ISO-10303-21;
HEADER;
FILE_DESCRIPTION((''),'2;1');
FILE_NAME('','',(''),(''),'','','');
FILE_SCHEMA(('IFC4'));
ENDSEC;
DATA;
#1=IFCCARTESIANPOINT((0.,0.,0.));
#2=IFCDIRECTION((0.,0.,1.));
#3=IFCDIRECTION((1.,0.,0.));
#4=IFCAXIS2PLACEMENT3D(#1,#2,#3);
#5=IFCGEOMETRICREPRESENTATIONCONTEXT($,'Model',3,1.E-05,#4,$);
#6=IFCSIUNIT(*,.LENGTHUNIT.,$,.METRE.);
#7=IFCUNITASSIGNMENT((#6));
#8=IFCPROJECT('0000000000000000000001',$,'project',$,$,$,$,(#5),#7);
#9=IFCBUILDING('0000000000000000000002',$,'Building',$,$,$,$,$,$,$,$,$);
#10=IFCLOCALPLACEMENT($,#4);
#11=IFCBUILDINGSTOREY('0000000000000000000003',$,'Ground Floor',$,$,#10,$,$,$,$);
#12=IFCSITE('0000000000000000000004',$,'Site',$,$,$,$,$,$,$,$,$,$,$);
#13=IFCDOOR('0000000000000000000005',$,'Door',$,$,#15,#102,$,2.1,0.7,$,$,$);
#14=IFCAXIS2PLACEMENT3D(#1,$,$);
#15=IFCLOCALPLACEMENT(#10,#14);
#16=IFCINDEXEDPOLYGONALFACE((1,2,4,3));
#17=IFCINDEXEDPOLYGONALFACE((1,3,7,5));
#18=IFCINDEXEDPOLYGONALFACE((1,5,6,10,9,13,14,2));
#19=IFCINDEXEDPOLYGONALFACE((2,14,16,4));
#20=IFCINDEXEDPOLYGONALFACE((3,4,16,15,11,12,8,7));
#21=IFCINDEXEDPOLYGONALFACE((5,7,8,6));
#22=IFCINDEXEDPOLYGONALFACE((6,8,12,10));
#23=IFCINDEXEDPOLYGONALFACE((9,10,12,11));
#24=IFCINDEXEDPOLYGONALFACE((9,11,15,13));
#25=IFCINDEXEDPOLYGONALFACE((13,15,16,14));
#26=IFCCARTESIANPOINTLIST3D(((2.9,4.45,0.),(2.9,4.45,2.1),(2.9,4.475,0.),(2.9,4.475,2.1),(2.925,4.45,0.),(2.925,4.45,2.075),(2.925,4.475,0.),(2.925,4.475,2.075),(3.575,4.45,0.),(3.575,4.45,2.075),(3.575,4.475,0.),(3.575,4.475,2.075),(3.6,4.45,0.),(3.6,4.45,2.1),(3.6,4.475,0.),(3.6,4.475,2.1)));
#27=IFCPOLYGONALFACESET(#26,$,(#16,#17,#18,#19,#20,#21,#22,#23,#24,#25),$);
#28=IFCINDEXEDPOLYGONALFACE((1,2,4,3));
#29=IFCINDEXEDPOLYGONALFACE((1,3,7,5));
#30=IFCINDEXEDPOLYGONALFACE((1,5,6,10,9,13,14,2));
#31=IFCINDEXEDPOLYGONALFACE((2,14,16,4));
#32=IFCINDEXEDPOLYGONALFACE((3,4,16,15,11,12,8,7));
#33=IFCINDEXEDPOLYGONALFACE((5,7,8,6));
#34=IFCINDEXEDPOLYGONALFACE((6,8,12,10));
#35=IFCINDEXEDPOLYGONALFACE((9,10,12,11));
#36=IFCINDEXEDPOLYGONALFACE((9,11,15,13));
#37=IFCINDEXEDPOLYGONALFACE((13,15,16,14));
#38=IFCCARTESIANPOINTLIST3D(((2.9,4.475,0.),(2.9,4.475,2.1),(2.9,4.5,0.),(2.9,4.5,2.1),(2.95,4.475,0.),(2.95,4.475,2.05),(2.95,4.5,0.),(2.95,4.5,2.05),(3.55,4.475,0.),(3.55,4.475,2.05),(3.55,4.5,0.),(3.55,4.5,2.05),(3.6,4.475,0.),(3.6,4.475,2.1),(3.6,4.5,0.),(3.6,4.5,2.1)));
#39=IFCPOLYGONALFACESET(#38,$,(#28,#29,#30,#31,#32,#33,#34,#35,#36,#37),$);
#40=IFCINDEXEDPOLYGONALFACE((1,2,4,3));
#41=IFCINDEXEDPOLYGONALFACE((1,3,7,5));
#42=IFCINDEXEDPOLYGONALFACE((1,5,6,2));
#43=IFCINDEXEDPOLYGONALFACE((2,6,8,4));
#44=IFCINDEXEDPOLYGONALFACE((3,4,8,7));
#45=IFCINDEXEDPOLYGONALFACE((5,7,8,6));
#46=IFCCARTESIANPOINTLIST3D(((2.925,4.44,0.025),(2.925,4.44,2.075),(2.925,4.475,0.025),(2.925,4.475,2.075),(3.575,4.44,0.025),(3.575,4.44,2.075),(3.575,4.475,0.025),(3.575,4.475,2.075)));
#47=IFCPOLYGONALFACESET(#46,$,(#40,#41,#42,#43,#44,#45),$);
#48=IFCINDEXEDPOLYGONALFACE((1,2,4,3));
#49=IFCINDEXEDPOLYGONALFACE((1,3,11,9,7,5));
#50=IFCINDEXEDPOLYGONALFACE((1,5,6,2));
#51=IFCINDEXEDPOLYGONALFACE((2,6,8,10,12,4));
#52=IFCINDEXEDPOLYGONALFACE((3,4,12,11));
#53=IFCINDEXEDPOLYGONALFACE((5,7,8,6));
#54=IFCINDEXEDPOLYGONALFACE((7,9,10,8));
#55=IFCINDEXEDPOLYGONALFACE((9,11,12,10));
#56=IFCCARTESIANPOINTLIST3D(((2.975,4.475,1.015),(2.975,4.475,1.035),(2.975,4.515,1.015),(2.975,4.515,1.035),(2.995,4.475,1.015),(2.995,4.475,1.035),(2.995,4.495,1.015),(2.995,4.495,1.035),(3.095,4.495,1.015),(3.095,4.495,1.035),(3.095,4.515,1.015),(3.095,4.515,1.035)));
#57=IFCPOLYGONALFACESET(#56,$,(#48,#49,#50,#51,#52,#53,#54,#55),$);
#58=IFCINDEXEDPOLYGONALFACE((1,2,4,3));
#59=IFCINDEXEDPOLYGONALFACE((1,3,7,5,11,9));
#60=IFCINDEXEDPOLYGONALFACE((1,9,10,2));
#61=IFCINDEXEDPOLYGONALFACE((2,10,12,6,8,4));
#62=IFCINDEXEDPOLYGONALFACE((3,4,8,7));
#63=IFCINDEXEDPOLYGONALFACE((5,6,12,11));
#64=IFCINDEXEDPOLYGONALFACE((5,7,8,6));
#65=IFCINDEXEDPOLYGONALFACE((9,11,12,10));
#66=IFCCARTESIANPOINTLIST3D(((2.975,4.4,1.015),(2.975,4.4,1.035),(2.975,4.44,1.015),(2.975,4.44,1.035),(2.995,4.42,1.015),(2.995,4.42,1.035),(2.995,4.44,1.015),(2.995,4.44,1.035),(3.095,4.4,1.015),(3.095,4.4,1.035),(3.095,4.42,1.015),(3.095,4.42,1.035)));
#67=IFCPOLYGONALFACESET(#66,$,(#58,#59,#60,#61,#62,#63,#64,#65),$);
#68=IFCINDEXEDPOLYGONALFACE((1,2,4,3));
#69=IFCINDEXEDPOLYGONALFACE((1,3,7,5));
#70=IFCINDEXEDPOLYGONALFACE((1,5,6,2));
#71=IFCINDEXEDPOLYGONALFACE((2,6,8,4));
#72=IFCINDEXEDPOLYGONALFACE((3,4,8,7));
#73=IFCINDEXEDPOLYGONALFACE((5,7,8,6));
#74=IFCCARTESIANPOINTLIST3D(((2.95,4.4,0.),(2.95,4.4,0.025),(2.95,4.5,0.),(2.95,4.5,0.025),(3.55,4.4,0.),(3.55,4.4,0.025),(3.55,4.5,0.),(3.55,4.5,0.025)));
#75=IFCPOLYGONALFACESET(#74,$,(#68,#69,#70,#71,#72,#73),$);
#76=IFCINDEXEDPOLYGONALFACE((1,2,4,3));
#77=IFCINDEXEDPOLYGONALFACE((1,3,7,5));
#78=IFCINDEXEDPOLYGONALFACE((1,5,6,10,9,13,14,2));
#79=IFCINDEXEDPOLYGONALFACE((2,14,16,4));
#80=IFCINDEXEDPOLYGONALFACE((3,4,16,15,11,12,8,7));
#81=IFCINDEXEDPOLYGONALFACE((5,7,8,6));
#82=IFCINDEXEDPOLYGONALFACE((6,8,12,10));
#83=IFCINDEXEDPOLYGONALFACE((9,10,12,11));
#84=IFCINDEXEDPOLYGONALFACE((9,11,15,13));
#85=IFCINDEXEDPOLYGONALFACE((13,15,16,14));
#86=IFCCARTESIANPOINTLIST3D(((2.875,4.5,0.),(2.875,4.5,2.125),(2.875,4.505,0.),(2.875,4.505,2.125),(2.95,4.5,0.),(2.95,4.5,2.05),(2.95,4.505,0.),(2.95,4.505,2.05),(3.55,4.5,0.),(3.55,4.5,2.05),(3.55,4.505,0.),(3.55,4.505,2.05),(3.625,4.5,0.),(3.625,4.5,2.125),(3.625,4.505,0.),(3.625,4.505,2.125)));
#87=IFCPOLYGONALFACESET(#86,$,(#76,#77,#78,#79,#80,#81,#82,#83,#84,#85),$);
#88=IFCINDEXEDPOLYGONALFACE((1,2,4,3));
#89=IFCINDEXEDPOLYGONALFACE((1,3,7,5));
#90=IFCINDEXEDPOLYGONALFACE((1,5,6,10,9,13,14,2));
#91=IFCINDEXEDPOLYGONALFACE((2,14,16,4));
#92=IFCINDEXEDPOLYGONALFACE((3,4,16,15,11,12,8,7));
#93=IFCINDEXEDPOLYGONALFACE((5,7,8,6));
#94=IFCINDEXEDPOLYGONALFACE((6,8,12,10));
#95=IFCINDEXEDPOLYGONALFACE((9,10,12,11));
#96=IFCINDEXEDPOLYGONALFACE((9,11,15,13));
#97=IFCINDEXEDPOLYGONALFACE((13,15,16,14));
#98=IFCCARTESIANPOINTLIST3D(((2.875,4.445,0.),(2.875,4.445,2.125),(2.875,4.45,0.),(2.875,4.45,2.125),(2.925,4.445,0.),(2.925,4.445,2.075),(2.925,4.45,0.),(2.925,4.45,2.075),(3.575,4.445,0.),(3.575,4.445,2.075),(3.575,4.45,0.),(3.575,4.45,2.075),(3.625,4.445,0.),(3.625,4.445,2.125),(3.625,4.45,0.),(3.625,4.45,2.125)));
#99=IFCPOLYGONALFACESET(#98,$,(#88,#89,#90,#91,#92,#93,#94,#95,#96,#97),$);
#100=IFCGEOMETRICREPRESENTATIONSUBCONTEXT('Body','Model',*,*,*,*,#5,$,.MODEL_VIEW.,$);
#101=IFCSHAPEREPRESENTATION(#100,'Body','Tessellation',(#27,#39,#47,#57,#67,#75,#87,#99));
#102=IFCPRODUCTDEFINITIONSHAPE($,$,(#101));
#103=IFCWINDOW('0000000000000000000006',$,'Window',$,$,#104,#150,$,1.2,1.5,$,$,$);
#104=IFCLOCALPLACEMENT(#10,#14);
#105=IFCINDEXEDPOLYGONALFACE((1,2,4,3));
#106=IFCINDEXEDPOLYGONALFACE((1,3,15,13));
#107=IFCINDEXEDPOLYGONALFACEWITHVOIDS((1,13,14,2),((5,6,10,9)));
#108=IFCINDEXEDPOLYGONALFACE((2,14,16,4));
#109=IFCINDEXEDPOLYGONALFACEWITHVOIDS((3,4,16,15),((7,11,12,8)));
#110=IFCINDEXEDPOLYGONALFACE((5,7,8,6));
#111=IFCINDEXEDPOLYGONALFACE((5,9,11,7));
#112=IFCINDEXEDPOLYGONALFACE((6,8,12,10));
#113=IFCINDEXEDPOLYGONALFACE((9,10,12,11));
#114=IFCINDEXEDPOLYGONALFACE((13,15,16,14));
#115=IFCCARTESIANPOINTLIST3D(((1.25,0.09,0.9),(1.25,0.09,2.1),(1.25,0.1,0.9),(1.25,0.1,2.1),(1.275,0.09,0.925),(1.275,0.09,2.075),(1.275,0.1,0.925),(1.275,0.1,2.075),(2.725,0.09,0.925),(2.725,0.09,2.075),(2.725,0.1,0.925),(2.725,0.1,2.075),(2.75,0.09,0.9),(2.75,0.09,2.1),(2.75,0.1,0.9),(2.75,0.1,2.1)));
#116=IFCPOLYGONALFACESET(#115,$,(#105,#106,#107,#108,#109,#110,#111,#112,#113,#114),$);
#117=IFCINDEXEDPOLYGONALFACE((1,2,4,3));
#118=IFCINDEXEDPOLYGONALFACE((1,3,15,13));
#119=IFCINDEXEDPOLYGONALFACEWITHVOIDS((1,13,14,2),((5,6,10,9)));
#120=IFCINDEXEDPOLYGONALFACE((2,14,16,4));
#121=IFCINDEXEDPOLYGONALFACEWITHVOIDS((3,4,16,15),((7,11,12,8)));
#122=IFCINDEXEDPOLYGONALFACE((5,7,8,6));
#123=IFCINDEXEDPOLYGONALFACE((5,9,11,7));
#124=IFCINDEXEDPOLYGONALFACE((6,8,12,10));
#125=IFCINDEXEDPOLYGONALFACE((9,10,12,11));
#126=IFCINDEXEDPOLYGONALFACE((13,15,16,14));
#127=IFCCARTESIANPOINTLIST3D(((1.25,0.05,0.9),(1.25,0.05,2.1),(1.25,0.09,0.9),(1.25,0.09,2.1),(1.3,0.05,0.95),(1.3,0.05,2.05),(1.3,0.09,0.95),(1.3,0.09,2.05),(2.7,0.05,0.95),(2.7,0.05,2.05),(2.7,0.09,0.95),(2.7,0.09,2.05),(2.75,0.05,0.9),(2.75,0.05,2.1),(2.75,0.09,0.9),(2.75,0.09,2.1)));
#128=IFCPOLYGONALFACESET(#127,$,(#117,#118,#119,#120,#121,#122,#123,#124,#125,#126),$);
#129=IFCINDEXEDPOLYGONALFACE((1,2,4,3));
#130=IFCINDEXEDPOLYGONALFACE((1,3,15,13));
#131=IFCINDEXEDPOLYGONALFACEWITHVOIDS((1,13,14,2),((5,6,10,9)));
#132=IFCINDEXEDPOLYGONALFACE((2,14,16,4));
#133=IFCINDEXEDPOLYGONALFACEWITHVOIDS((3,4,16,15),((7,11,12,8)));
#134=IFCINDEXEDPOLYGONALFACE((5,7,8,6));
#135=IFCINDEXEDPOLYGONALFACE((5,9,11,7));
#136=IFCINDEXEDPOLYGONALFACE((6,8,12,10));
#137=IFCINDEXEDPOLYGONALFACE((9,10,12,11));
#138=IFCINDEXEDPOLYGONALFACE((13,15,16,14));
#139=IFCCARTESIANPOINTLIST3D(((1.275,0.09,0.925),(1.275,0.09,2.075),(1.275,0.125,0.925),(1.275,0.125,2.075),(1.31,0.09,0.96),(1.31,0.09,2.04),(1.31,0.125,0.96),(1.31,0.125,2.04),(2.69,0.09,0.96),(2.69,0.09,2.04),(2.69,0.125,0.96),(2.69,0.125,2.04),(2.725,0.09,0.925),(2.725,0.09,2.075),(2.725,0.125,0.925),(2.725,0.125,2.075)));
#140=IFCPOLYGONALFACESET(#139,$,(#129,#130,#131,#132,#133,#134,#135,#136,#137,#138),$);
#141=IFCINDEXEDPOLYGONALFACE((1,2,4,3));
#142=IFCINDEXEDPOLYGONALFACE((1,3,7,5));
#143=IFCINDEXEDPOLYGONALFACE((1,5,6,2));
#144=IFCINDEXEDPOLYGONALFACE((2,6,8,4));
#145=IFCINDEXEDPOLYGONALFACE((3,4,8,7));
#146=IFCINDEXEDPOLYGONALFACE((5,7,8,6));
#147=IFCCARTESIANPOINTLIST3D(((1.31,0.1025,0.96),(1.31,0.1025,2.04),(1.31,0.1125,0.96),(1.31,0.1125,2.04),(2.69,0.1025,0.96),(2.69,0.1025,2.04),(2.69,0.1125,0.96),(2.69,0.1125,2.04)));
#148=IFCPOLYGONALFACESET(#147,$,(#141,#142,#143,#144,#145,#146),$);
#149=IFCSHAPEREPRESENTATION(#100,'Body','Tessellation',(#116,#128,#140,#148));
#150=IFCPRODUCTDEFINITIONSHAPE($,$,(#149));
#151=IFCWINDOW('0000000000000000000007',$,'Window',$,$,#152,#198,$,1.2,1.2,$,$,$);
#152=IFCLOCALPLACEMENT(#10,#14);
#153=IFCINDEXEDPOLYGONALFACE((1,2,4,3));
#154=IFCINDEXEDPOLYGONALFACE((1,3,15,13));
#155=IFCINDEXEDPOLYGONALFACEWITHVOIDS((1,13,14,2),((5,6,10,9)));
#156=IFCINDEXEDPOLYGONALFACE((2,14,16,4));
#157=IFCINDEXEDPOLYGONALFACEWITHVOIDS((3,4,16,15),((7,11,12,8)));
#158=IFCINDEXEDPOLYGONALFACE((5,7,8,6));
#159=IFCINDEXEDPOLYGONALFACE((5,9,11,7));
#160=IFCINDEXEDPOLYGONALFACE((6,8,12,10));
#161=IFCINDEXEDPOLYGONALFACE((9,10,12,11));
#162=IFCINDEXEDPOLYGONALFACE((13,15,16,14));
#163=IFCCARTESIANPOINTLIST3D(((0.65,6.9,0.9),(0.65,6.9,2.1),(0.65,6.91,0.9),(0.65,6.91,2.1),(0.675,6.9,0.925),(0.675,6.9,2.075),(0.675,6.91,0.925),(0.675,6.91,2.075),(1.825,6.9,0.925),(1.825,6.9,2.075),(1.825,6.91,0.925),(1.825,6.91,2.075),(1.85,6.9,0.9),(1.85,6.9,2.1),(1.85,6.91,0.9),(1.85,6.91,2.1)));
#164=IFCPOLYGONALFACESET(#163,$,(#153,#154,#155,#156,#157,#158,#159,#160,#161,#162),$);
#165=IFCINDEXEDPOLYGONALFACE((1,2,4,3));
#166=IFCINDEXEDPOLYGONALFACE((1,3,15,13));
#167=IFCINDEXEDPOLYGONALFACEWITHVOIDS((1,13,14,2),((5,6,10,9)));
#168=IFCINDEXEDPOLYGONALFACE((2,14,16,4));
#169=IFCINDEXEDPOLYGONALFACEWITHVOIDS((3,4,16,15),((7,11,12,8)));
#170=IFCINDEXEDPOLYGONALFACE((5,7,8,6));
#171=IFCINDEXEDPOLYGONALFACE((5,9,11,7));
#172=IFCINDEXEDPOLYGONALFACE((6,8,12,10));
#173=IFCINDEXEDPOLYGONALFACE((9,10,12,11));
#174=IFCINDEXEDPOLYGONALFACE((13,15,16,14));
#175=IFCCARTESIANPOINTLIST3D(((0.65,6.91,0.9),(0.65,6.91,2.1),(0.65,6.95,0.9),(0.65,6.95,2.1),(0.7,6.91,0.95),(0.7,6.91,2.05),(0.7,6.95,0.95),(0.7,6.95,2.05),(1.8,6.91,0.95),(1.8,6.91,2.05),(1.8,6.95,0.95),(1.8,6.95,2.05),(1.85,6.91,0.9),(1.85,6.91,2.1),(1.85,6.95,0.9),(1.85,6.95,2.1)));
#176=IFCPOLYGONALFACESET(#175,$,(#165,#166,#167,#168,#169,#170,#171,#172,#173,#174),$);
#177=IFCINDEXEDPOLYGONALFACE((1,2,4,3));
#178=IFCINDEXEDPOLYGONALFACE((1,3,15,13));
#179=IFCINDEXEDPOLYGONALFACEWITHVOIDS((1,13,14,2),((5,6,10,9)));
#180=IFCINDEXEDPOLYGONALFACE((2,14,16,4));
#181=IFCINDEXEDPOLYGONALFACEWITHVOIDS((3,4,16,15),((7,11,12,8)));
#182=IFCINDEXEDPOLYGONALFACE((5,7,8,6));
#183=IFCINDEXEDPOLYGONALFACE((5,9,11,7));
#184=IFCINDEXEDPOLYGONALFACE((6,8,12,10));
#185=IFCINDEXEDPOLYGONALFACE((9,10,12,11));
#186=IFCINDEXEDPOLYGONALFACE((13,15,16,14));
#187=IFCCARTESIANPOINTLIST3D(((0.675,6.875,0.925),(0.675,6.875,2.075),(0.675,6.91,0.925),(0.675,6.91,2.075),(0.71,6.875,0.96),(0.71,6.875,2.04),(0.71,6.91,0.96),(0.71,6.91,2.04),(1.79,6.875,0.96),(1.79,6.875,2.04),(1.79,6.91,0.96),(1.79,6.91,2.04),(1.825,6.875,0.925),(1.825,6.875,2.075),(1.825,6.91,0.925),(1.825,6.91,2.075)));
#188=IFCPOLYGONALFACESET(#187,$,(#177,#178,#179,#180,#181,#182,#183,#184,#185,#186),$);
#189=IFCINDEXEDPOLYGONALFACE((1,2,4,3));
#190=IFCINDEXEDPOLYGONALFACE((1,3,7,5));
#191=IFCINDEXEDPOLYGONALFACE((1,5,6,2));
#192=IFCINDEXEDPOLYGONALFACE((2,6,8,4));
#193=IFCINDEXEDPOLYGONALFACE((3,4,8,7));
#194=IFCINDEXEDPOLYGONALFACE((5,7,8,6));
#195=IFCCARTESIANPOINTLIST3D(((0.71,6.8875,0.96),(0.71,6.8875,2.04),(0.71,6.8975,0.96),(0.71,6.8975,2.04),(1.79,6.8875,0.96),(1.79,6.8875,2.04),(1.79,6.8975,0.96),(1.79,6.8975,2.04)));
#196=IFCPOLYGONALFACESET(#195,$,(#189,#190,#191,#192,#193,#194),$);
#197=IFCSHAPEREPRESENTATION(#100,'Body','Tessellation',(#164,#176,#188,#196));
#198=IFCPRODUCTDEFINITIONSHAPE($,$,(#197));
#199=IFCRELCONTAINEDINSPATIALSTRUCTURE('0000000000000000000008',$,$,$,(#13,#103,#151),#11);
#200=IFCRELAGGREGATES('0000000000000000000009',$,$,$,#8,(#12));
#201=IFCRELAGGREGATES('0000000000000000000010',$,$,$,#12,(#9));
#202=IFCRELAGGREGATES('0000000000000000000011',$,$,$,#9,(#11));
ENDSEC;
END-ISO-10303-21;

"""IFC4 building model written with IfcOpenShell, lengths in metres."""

from ifc_helpers import new_model, si_unit, frame, origin_with_axes, place, context, subcontext, project, spatial, line, indexed_curve, outline, extrude, element, save


model = new_model("IFC4")

# Units and contexts
model_context = context("Model", 3, precision=1e-05, world=origin_with_axes())
body_context = subcontext(model_context, "Body", "Model", "MODEL_VIEW")
ifc_project = project(units=[si_unit("LENGTHUNIT", "METRE")], contexts=[model_context])

# Site, building, storey
site = spatial("IfcSite", under=ifc_project, Name="Site")
building = spatial("IfcBuilding", under=site, Name="Building")
storey_placement = place(None, origin_with_axes())
storey = spatial("IfcBuildingStorey", under=building, at=storey_placement, Name="Ground Floor")

# Door
door_1_placement = place(storey_placement, frame((3.6, 4.5, 0.0), z_axis=(0.0, 0.0, 1.0), x_axis=(-1.0, 0.0, 0.0)))
element("IfcDoor", 1, at=door_1_placement, inside=storey, Name="Door", OverallHeight=2.1, OverallWidth=0.7, context=body_context, shape_type="SweptSolid", body=[
    extrude(outline(indexed_curve([(0.0, 0.0), (0.0, 2.1), (0.7, 2.1), (0.7, 0.0), (0.675, 0.0), (0.675, 2.075), (0.025, 2.075), (0.025, 0.0)], segments=[line(1, 2, 3, 4, 5, 6, 7, 8, 1)])), frame((0.0, 0.025, 0.0), z_axis=(0.0, -1.0, 0.0), x_axis=(1.0, 0.0, 0.0)), (0.0, 0.0, -1.0), 0.025),
    extrude(outline(indexed_curve([(0.0, 0.0), (0.0, 2.1), (0.7, 2.1), (0.7, 0.0), (0.65, 0.0), (0.65, 2.05), (0.05, 2.05), (0.05, 0.0)], segments=[line(1, 2, 3, 4, 5, 6, 7, 8, 1)])), frame((0.0, 0.0, 0.0), z_axis=(0.0, -1.0, 0.0), x_axis=(1.0, 0.0, 0.0)), (0.0, 0.0, -1.0), 0.025),
    extrude(outline(indexed_curve([(0.0, 0.0), (0.65, 0.0), (0.65, 0.035), (0.0, 0.035)], segments=[line(1, 2, 3, 4, 1)])), frame((0.025, 0.025, 0.025), z_axis=(0.0, 0.0, 1.0), x_axis=(1.0, 0.0, 0.0)), (0.0, 0.0, 1.0), 2.05),
    extrude(outline(indexed_curve([(0.0, 0.0), (0.0, -0.04), (-0.12, -0.04), (-0.12, -0.02), (-0.02, -0.02), (-0.02, 0.0)], segments=[line(1, 2, 3, 4, 5, 6, 1)])), frame((0.625, 0.025, 1.015), z_axis=(0.0, 0.0, 1.0), x_axis=(1.0, 0.0, 0.0)), (0.0, 0.0, 1.0), 0.02),
    extrude(outline(indexed_curve([(0.0, 0.0), (0.0, 0.04), (-0.12, 0.04), (-0.12, 0.02), (-0.02, 0.02), (-0.02, 0.0)], segments=[line(1, 2, 3, 4, 5, 6, 1)])), frame((0.625, 0.06, 1.015), z_axis=(0.0, 0.0, 1.0), x_axis=(1.0, 0.0, 0.0)), (0.0, 0.0, 1.0), 0.02),
    extrude(outline(indexed_curve([(0.0, 0.0), (0.6, 0.0), (0.6, 0.1), (0.0, 0.1)], segments=[line(1, 2, 3, 4, 1)])), frame((0.05, 0.0, 0.0), z_axis=(0.0, 0.0, 1.0), x_axis=(1.0, 0.0, 0.0)), (0.0, 0.0, 1.0), 0.025),
    extrude(outline(indexed_curve([(0.0, 0.0), (0.0, 2.125), (0.75, 2.125), (0.75, 0.0), (0.675, 0.0), (0.675, 2.05), (0.075, 2.05), (0.075, 0.0)], segments=[line(1, 2, 3, 4, 5, 6, 7, 8, 1)])), frame((-0.025, -0.005, 0.0), z_axis=(0.0, -1.0, 0.0), x_axis=(1.0, 0.0, 0.0)), (0.0, 0.0, -1.0), 0.005),
    extrude(outline(indexed_curve([(0.0, 0.0), (0.0, 2.125), (0.75, 2.125), (0.75, 0.0), (0.7, 0.0), (0.7, 2.075), (0.05, 2.075), (0.05, 0.0)], segments=[line(1, 2, 3, 4, 5, 6, 7, 8, 1)])), frame((-0.025, 0.05, 0.0), z_axis=(0.0, -1.0, 0.0), x_axis=(1.0, 0.0, 0.0)), (0.0, 0.0, -1.0), 0.005),
])

# Windows
window_1_placement = place(storey_placement, frame((1.25, 0.0, 0.9), z_axis=(0.0, 0.0, 1.0), x_axis=(1.0, 0.0, 0.0)))
element("IfcWindow", 2, at=window_1_placement, inside=storey, Name="Window", OverallHeight=1.2, OverallWidth=1.5, context=body_context, shape_type="SweptSolid", body=[
    extrude(outline(indexed_curve([(0.0, 0.0), (1.5, 0.0), (1.5, 1.2), (0.0, 1.2)], segments=[line(1, 2, 3, 4, 1)]), holes=[indexed_curve([(0.025, 0.025), (1.475, 0.025), (1.475, 1.175), (0.025, 1.175)], segments=[line(1, 2, 3, 4, 1)])]), frame((0.0, 0.09, 0.0), z_axis=(0.0, -1.0, 0.0), x_axis=(1.0, 0.0, 0.0)), (0.0, 0.0, -1.0), 0.01),
    extrude(outline(indexed_curve([(0.0, 0.0), (1.5, 0.0), (1.5, 1.2), (0.0, 1.2)], segments=[line(1, 2, 3, 4, 1)]), holes=[indexed_curve([(0.05, 0.05), (1.45, 0.05), (1.45, 1.15), (0.05, 1.15)], segments=[line(1, 2, 3, 4, 1)])]), frame((0.0, 0.05, 0.0), z_axis=(0.0, -1.0, 0.0), x_axis=(1.0, 0.0, 0.0)), (0.0, 0.0, -1.0), 0.04),
    extrude(outline(indexed_curve([(0.0, 0.0), (1.45, 0.0), (1.45, 1.15), (0.0, 1.15)], segments=[line(1, 2, 3, 4, 1)]), holes=[indexed_curve([(0.035, 0.035), (1.415, 0.035), (1.415, 1.115), (0.035, 1.115)], segments=[line(1, 2, 3, 4, 1)])]), frame((0.025, 0.09, 0.025), z_axis=(0.0, -1.0, 0.0), x_axis=(1.0, 0.0, 0.0)), (0.0, 0.0, -1.0), 0.035),
    extrude(outline(indexed_curve([(0.035, 0.035), (1.415, 0.035), (1.415, 1.115), (0.035, 1.115)], segments=[line(1, 2, 3, 4, 1)])), frame((0.025, 0.1025, 0.025), z_axis=(0.0, -1.0, 0.0), x_axis=(1.0, 0.0, 0.0)), (0.0, 0.0, -1.0), 0.01),
])
window_2_placement = place(storey_placement, frame((1.85, 7.0, 0.9), z_axis=(0.0, 0.0, 1.0), x_axis=(-1.0, 0.0, 0.0)))
element("IfcWindow", 3, at=window_2_placement, inside=storey, Name="Window", OverallHeight=1.2, OverallWidth=1.2, context=body_context, shape_type="SweptSolid", body=[
    extrude(outline(indexed_curve([(0.0, 0.0), (1.2, 0.0), (1.2, 1.2), (0.0, 1.2)], segments=[line(1, 2, 3, 4, 1)]), holes=[indexed_curve([(0.025, 0.025), (1.175, 0.025), (1.175, 1.175), (0.025, 1.175)], segments=[line(1, 2, 3, 4, 1)])]), frame((0.0, 0.09, 0.0), z_axis=(0.0, -1.0, 0.0), x_axis=(1.0, 0.0, 0.0)), (0.0, 0.0, -1.0), 0.01),
    extrude(outline(indexed_curve([(0.0, 0.0), (1.2, 0.0), (1.2, 1.2), (0.0, 1.2)], segments=[line(1, 2, 3, 4, 1)]), holes=[indexed_curve([(0.05, 0.05), (1.15, 0.05), (1.15, 1.15), (0.05, 1.15)], segments=[line(1, 2, 3, 4, 1)])]), frame((0.0, 0.05, 0.0), z_axis=(0.0, -1.0, 0.0), x_axis=(1.0, 0.0, 0.0)), (0.0, 0.0, -1.0), 0.04),
    extrude(outline(indexed_curve([(0.0, 0.0), (1.15, 0.0), (1.15, 1.15), (0.0, 1.15)], segments=[line(1, 2, 3, 4, 1)]), holes=[indexed_curve([(0.035, 0.035), (1.115, 0.035), (1.115, 1.115), (0.035, 1.115)], segments=[line(1, 2, 3, 4, 1)])]), frame((0.025, 0.09, 0.025), z_axis=(0.0, -1.0, 0.0), x_axis=(1.0, 0.0, 0.0)), (0.0, 0.0, -1.0), 0.035),
    extrude(outline(indexed_curve([(0.035, 0.035), (1.115, 0.035), (1.115, 1.115), (0.035, 1.115)], segments=[line(1, 2, 3, 4, 1)])), frame((0.025, 0.1025, 0.025), z_axis=(0.0, -1.0, 0.0), x_axis=(1.0, 0.0, 0.0)), (0.0, 0.0, -1.0), 0.01),
])

save(model, "model.ifc")
